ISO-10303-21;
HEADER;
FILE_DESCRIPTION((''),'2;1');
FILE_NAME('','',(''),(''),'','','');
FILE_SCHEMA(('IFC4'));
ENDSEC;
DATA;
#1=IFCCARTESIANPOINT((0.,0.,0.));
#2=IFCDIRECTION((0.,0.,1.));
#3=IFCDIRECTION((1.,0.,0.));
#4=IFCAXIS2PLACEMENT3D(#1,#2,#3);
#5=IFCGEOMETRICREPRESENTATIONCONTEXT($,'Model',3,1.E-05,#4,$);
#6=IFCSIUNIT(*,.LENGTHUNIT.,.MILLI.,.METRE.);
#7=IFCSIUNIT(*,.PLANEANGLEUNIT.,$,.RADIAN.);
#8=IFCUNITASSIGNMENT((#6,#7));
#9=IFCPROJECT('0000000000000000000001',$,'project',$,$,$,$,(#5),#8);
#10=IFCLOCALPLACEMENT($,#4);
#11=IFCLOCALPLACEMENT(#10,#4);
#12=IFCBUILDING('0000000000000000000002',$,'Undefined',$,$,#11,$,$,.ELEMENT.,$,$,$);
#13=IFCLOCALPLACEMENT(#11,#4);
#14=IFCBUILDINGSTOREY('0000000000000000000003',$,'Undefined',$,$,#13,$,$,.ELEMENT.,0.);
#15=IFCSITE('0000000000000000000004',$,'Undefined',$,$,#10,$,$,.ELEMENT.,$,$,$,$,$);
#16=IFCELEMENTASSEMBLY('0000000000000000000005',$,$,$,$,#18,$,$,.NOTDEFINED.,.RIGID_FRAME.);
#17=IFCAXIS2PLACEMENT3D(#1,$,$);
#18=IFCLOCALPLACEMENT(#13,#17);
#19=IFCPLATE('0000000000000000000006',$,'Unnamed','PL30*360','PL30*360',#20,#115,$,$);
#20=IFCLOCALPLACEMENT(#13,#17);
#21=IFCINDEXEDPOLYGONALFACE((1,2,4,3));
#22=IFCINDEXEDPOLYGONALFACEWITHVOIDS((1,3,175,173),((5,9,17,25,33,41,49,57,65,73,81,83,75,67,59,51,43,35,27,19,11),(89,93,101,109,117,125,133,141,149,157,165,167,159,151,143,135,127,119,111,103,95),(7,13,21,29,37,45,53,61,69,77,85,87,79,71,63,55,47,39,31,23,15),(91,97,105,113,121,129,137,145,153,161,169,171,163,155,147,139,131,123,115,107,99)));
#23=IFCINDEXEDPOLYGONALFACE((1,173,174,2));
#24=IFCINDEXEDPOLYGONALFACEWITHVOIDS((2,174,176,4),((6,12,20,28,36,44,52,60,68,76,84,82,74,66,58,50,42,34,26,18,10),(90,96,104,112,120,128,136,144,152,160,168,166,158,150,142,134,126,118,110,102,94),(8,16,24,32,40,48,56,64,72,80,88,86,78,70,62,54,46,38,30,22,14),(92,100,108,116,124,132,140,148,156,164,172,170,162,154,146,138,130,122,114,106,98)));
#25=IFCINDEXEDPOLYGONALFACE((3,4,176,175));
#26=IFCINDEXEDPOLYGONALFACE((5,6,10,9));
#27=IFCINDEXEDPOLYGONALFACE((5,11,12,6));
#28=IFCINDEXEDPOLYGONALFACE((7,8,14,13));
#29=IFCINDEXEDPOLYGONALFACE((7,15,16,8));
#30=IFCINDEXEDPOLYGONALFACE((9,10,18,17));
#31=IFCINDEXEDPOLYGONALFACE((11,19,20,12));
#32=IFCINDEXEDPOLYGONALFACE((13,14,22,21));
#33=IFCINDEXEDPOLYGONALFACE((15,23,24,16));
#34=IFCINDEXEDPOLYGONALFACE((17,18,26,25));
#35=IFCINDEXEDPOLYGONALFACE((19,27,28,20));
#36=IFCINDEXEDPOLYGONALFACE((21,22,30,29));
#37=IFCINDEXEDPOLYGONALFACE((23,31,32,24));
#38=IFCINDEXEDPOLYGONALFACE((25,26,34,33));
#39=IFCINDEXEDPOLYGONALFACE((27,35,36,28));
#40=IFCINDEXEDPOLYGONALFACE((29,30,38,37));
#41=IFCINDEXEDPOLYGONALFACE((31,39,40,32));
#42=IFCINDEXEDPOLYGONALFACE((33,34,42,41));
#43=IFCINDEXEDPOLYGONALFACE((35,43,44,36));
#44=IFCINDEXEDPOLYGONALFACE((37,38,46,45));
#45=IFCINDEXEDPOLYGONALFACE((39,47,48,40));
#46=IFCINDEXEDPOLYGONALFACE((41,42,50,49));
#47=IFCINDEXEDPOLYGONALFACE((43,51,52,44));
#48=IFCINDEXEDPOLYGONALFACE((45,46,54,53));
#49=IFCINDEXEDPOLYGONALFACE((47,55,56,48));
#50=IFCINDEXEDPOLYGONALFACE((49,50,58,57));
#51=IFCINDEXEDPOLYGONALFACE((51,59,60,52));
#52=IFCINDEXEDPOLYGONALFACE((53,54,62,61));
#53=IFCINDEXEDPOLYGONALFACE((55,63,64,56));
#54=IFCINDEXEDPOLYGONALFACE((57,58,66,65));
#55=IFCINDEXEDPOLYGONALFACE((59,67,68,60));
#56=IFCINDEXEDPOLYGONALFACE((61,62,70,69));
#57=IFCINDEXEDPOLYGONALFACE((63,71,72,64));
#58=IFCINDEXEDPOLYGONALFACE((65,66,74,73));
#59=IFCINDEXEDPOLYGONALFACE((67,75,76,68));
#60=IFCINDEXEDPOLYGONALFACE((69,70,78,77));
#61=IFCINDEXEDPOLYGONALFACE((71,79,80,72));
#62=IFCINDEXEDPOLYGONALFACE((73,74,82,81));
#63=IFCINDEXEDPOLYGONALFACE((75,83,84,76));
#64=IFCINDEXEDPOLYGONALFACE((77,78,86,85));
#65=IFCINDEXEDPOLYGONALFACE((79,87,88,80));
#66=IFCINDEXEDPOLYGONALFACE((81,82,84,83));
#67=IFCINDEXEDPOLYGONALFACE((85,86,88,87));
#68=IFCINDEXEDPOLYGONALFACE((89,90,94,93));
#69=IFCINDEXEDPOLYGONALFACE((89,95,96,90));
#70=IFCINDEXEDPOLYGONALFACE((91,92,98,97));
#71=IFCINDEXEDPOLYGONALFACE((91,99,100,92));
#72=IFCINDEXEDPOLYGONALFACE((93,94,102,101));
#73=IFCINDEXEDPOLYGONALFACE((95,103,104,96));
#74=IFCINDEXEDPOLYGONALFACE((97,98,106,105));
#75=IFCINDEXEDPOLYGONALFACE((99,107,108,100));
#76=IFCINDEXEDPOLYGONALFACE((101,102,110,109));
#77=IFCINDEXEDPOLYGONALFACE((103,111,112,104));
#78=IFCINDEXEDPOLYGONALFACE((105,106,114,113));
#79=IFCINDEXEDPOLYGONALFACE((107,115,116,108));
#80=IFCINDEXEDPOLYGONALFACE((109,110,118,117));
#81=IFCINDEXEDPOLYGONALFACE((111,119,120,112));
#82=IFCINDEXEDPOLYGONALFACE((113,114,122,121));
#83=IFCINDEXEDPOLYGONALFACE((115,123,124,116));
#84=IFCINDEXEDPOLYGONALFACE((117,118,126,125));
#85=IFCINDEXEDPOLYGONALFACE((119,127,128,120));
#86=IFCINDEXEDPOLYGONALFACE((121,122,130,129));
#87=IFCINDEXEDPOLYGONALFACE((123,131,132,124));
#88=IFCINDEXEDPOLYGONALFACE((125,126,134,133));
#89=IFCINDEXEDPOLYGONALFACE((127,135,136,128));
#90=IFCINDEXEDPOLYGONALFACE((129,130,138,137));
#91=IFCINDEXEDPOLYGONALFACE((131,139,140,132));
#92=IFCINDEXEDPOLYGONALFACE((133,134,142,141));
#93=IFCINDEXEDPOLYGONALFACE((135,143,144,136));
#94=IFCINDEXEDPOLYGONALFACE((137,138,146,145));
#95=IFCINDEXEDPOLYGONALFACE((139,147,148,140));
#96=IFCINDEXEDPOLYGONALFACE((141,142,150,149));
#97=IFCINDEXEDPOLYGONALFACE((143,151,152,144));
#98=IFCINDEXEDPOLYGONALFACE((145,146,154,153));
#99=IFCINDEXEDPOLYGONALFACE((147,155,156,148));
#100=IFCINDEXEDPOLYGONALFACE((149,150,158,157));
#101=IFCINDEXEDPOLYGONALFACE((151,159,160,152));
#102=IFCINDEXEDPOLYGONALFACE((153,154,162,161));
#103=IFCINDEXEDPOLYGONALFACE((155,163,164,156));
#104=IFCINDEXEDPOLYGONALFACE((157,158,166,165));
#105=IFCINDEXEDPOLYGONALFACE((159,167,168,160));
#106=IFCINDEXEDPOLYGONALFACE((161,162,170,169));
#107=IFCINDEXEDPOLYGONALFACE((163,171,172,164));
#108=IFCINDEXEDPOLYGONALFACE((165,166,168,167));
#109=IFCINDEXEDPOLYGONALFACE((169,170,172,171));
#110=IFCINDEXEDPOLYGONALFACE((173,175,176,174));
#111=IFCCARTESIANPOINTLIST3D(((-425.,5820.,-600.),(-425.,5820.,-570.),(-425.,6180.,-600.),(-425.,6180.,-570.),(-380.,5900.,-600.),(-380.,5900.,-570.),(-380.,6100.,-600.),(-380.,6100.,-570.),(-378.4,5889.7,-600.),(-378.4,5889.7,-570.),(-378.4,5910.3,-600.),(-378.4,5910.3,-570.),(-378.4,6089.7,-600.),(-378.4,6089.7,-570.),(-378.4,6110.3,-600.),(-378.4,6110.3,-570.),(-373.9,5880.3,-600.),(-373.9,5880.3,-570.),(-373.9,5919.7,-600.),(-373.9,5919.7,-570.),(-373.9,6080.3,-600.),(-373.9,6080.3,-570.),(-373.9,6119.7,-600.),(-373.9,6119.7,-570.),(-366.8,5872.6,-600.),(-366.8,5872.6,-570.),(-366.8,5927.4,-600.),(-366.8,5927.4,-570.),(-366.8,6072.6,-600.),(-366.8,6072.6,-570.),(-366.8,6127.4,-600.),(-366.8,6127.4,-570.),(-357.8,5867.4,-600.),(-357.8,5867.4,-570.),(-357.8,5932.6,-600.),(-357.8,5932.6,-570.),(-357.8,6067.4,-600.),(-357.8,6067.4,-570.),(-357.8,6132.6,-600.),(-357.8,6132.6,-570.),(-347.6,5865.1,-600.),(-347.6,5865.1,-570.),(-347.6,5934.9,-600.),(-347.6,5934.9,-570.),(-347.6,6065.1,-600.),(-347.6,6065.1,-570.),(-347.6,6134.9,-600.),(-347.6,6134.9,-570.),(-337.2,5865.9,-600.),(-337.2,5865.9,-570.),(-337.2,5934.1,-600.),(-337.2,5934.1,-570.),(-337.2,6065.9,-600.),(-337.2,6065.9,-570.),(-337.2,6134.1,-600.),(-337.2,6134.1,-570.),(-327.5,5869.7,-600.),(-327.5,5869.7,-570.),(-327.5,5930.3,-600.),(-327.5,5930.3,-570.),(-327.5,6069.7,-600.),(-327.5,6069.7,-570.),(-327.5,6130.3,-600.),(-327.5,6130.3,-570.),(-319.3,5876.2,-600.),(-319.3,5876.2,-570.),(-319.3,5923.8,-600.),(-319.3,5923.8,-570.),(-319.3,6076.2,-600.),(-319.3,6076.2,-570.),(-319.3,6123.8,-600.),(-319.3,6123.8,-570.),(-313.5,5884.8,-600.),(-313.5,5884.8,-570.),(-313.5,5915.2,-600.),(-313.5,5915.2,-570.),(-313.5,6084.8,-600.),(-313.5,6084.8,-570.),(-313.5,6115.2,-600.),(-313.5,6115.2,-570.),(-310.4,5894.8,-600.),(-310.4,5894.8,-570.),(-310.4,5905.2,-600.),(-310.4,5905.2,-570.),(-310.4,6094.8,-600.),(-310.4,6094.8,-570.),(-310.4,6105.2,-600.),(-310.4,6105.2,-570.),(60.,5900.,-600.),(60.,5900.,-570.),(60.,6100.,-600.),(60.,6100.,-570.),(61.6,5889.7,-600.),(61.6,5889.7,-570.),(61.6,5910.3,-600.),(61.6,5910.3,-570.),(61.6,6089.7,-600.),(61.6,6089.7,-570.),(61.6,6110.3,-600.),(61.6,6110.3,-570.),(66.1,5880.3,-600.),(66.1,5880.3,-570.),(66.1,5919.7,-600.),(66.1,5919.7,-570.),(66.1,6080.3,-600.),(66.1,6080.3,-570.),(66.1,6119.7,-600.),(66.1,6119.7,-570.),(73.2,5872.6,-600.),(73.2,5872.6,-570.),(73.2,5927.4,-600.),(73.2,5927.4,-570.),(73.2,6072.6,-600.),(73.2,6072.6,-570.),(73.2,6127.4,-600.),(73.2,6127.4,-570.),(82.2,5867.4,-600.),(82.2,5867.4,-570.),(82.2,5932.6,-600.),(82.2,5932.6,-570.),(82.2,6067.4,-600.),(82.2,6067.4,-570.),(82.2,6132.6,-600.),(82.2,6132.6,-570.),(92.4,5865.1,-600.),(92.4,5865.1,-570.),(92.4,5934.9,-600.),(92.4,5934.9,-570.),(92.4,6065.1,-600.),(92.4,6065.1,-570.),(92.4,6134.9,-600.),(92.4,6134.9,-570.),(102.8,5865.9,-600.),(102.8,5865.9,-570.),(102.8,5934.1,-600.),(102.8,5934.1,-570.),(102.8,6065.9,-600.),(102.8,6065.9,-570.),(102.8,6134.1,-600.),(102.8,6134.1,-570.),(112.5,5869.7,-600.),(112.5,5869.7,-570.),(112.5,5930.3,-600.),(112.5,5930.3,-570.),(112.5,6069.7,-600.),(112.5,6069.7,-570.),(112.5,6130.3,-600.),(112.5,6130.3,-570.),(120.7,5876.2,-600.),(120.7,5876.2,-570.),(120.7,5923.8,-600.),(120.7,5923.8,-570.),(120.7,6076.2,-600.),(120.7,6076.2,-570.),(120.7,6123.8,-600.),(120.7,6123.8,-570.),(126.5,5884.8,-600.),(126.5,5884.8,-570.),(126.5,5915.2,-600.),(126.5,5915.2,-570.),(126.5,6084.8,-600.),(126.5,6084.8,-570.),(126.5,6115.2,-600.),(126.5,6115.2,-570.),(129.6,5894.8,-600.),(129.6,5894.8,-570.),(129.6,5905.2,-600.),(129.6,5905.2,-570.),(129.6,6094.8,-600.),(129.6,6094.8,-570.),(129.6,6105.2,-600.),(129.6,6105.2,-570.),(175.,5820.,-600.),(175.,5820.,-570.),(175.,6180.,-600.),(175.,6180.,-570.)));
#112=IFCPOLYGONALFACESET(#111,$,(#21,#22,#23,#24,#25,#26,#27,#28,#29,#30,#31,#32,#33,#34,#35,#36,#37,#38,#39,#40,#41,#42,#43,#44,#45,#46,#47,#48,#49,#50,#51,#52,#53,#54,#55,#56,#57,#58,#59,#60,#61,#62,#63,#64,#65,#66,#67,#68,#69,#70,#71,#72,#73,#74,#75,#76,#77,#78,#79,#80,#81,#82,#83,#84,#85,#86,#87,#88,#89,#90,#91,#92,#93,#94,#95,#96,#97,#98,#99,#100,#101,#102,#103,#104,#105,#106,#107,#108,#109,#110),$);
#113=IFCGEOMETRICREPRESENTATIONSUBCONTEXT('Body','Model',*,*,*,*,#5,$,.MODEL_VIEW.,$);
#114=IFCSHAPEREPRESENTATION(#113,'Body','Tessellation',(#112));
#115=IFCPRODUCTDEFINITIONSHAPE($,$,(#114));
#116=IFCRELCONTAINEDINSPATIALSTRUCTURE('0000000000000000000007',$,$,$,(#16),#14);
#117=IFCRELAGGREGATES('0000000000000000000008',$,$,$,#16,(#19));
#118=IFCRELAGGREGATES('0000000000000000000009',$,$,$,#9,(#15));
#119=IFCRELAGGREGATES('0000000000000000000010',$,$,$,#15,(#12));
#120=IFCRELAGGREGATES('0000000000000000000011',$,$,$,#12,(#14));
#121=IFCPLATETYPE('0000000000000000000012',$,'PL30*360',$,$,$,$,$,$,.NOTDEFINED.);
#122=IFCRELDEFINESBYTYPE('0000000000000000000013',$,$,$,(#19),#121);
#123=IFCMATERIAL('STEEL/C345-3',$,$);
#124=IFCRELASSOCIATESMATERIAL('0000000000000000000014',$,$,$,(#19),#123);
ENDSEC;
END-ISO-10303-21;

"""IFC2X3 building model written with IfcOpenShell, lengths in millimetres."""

from ifc_helpers import new_model, si_unit, frame, origin_with_axes, origin_2d_with_axis, place, context, subcontext, project, spatial, polyline, circle, outline, extrude, boolean, material, type_object, element, aggregate, save


model = new_model("IFC2X3")

# Units and contexts
model_context = context("Model", 3, precision=1e-05, world=origin_with_axes())
body_context = subcontext(model_context, "Body", "Model", "MODEL_VIEW")
ifc_project = project(units=[si_unit("LENGTHUNIT", "METRE", prefix="MILLI"), si_unit("PLANEANGLEUNIT", "RADIAN")], contexts=[model_context])

# Site, building, storey
site_placement = place(None, origin_with_axes())
site = spatial("IfcSite", under=ifc_project, at=site_placement, Name="Undefined", CompositionType="ELEMENT")
building_placement = place(site_placement, origin_with_axes())
building = spatial("IfcBuilding", under=site, at=building_placement, Name="Undefined", CompositionType="ELEMENT")
storey_placement = place(building_placement, origin_with_axes())
storey = spatial("IfcBuildingStorey", under=building, at=storey_placement, Name="Undefined", CompositionType="ELEMENT", Elevation=0.0)

# Shared definitions
ifc_material_1 = material(Name="STEEL/C345-3")

# Element assembly, plate
plate_type_1 = type_object("IfcPlateType", Name="PL30*360", PredefinedType="NOTDEFINED")
assembly_1_placement = place(storey_placement, origin_with_axes())
assembly_1 = element("IfcElementAssembly", 1, at=assembly_1_placement, inside=storey, AssemblyPlace="NOTDEFINED", PredefinedType="RIGID_FRAME")
plate_1_placement = place(assembly_1_placement, frame((-425.0, 6180.0, -585.0), z_axis=(0.0, 0.0, 1.0), x_axis=(0.0, -1.0, 0.0)))
plate_1 = element("IfcPlate", 2, at=plate_1_placement, type_object=plate_type_1, material=ifc_material_1, Name="Unnamed", Description="PL30*360", ObjectType="PL30*360", context=body_context, shape_type="CSG", body=[
    boolean("DIFFERENCE", boolean("DIFFERENCE", boolean("DIFFERENCE", boolean("DIFFERENCE", extrude(outline(polyline([(0.0, 0.0), (360.0, 0.0), (360.0, 600.0), (0.0, 600.0), (0.0, 0.0)])), frame((0.0, 0.0, -15.0), z_axis=(0.0, 0.0, 1.0), x_axis=(1.0, 0.0, 0.0)), (0.0, 0.0, 1.0), 30.0), extrude(circle(Radius=35.0, at=origin_2d_with_axis()), frame((80.0, 520.0, 25.0), z_axis=(0.0, 0.0, -1.0), x_axis=(0.0, -1.0, 0.0)), (0.0, 0.0, 1.0), 60.0)), extrude(circle(Radius=35.0, at=origin_2d_with_axis()), frame((280.0, 520.0, 25.0), z_axis=(0.0, 0.0, -1.0), x_axis=(0.0, -1.0, 0.0)), (0.0, 0.0, 1.0), 60.0)), extrude(circle(Radius=35.0, at=origin_2d_with_axis()), frame((80.0, 80.0, 25.0), z_axis=(0.0, 0.0, -1.0), x_axis=(0.0, -1.0, 0.0)), (0.0, 0.0, 1.0), 60.0)), extrude(circle(Radius=35.0, at=origin_2d_with_axis()), frame((280.0, 80.0, 25.0), z_axis=(0.0, 0.0, -1.0), x_axis=(0.0, -1.0, 0.0)), (0.0, 0.0, 1.0), 60.0)),
])
aggregate(assembly_1, [plate_1])

save(model, "model.ifc")
